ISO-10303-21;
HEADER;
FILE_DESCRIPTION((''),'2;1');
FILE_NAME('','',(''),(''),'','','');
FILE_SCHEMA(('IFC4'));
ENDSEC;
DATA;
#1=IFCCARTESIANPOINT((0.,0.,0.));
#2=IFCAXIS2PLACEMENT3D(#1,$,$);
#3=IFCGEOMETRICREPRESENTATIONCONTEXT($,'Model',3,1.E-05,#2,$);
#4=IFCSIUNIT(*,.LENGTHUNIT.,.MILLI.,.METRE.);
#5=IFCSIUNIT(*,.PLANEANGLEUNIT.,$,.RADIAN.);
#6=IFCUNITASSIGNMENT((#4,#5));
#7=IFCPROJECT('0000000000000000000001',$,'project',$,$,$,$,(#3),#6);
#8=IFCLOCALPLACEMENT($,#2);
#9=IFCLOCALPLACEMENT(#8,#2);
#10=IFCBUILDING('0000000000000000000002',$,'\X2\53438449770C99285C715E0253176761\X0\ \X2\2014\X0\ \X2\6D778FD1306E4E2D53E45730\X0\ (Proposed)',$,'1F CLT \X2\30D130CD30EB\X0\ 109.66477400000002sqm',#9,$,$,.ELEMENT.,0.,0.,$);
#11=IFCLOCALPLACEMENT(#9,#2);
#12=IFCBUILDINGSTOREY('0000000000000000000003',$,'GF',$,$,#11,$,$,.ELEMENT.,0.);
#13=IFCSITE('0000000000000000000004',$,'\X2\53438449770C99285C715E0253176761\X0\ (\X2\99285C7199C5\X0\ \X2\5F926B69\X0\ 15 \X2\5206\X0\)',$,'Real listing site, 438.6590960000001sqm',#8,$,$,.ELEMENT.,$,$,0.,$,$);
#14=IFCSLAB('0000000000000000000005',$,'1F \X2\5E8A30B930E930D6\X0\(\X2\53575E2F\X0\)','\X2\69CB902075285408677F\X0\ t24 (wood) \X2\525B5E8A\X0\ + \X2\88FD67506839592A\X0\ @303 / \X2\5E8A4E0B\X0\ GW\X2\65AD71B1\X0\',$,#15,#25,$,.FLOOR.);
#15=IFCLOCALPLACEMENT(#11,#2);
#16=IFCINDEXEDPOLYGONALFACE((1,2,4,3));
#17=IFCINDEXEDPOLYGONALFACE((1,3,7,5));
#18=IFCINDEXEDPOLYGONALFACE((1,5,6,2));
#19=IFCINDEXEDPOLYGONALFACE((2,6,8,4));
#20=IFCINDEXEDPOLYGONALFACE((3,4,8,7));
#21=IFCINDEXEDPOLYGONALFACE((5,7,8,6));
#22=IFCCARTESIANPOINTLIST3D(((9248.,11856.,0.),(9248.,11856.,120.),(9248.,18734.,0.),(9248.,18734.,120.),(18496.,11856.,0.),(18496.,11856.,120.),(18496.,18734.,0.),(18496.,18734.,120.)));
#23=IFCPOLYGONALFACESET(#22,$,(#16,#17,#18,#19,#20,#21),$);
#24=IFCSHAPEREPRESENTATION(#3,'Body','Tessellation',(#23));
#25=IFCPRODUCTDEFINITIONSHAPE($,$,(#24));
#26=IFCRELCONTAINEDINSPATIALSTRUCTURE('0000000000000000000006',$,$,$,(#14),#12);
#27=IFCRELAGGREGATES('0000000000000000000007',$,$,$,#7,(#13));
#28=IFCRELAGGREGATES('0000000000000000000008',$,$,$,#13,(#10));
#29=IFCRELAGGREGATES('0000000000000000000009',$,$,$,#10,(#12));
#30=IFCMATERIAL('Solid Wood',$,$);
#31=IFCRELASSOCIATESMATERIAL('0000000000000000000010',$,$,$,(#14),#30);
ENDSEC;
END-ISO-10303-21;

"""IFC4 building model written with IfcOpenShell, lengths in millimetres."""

from ifc_helpers import new_model, si_unit, frame, frame_2d, origin, place, context, project, spatial, rectangle, extrude, material, element, save


model = new_model("IFC4")

# Units and contexts
model_context = context("Model", 3, precision=1e-05, world=origin())
ifc_project = project(units=[si_unit("LENGTHUNIT", "METRE", prefix="MILLI"), si_unit("PLANEANGLEUNIT", "RADIAN")], contexts=[model_context])

# Site, building, storey
site_placement = place(None, origin())
site = spatial("IfcSite", under=ifc_project, at=site_placement, Name="千葉県館山市北条 (館山駅 徒歩 15 分)", ObjectType="Real listing site, 438.6590960000001sqm", CompositionType="ELEMENT", RefElevation=0.0)
building_placement = place(site_placement, origin())
building = spatial("IfcBuilding", under=site, at=building_placement, Name="千葉県館山市北条 — 海近の中古地 (Proposed)", ObjectType="1F CLT パネル 109.66477400000002sqm", CompositionType="ELEMENT", ElevationOfRefHeight=0.0, ElevationOfTerrain=0.0)
storey_placement = place(building_placement, origin())
storey = spatial("IfcBuildingStorey", under=building, at=storey_placement, Name="GF", CompositionType="ELEMENT", Elevation=0.0)

# Slab
ifc_material_1 = material(Name="Solid Wood")
slab_1_placement = place(storey_placement, frame((4624.0, 5928.0, 0.0)))
element("IfcSlab", 1, at=slab_1_placement, inside=storey, material=ifc_material_1, Name="1F 床スラブ(南帯)", Description="構造用合板 t24 (wood) 剛床 + 製材根太 @303 / 床下 GW断熱", PredefinedType="FLOOR", context=model_context, shape_type="SweptSolid", body=[
    extrude(rectangle(XDim=9248.0, YDim=6878.0, at=frame_2d((4624.0, 3439.0))), frame((4624.0, 5928.0, 0.0)), (0.0, 0.0, 1.0), 120.0),
])

save(model, "model.ifc")
